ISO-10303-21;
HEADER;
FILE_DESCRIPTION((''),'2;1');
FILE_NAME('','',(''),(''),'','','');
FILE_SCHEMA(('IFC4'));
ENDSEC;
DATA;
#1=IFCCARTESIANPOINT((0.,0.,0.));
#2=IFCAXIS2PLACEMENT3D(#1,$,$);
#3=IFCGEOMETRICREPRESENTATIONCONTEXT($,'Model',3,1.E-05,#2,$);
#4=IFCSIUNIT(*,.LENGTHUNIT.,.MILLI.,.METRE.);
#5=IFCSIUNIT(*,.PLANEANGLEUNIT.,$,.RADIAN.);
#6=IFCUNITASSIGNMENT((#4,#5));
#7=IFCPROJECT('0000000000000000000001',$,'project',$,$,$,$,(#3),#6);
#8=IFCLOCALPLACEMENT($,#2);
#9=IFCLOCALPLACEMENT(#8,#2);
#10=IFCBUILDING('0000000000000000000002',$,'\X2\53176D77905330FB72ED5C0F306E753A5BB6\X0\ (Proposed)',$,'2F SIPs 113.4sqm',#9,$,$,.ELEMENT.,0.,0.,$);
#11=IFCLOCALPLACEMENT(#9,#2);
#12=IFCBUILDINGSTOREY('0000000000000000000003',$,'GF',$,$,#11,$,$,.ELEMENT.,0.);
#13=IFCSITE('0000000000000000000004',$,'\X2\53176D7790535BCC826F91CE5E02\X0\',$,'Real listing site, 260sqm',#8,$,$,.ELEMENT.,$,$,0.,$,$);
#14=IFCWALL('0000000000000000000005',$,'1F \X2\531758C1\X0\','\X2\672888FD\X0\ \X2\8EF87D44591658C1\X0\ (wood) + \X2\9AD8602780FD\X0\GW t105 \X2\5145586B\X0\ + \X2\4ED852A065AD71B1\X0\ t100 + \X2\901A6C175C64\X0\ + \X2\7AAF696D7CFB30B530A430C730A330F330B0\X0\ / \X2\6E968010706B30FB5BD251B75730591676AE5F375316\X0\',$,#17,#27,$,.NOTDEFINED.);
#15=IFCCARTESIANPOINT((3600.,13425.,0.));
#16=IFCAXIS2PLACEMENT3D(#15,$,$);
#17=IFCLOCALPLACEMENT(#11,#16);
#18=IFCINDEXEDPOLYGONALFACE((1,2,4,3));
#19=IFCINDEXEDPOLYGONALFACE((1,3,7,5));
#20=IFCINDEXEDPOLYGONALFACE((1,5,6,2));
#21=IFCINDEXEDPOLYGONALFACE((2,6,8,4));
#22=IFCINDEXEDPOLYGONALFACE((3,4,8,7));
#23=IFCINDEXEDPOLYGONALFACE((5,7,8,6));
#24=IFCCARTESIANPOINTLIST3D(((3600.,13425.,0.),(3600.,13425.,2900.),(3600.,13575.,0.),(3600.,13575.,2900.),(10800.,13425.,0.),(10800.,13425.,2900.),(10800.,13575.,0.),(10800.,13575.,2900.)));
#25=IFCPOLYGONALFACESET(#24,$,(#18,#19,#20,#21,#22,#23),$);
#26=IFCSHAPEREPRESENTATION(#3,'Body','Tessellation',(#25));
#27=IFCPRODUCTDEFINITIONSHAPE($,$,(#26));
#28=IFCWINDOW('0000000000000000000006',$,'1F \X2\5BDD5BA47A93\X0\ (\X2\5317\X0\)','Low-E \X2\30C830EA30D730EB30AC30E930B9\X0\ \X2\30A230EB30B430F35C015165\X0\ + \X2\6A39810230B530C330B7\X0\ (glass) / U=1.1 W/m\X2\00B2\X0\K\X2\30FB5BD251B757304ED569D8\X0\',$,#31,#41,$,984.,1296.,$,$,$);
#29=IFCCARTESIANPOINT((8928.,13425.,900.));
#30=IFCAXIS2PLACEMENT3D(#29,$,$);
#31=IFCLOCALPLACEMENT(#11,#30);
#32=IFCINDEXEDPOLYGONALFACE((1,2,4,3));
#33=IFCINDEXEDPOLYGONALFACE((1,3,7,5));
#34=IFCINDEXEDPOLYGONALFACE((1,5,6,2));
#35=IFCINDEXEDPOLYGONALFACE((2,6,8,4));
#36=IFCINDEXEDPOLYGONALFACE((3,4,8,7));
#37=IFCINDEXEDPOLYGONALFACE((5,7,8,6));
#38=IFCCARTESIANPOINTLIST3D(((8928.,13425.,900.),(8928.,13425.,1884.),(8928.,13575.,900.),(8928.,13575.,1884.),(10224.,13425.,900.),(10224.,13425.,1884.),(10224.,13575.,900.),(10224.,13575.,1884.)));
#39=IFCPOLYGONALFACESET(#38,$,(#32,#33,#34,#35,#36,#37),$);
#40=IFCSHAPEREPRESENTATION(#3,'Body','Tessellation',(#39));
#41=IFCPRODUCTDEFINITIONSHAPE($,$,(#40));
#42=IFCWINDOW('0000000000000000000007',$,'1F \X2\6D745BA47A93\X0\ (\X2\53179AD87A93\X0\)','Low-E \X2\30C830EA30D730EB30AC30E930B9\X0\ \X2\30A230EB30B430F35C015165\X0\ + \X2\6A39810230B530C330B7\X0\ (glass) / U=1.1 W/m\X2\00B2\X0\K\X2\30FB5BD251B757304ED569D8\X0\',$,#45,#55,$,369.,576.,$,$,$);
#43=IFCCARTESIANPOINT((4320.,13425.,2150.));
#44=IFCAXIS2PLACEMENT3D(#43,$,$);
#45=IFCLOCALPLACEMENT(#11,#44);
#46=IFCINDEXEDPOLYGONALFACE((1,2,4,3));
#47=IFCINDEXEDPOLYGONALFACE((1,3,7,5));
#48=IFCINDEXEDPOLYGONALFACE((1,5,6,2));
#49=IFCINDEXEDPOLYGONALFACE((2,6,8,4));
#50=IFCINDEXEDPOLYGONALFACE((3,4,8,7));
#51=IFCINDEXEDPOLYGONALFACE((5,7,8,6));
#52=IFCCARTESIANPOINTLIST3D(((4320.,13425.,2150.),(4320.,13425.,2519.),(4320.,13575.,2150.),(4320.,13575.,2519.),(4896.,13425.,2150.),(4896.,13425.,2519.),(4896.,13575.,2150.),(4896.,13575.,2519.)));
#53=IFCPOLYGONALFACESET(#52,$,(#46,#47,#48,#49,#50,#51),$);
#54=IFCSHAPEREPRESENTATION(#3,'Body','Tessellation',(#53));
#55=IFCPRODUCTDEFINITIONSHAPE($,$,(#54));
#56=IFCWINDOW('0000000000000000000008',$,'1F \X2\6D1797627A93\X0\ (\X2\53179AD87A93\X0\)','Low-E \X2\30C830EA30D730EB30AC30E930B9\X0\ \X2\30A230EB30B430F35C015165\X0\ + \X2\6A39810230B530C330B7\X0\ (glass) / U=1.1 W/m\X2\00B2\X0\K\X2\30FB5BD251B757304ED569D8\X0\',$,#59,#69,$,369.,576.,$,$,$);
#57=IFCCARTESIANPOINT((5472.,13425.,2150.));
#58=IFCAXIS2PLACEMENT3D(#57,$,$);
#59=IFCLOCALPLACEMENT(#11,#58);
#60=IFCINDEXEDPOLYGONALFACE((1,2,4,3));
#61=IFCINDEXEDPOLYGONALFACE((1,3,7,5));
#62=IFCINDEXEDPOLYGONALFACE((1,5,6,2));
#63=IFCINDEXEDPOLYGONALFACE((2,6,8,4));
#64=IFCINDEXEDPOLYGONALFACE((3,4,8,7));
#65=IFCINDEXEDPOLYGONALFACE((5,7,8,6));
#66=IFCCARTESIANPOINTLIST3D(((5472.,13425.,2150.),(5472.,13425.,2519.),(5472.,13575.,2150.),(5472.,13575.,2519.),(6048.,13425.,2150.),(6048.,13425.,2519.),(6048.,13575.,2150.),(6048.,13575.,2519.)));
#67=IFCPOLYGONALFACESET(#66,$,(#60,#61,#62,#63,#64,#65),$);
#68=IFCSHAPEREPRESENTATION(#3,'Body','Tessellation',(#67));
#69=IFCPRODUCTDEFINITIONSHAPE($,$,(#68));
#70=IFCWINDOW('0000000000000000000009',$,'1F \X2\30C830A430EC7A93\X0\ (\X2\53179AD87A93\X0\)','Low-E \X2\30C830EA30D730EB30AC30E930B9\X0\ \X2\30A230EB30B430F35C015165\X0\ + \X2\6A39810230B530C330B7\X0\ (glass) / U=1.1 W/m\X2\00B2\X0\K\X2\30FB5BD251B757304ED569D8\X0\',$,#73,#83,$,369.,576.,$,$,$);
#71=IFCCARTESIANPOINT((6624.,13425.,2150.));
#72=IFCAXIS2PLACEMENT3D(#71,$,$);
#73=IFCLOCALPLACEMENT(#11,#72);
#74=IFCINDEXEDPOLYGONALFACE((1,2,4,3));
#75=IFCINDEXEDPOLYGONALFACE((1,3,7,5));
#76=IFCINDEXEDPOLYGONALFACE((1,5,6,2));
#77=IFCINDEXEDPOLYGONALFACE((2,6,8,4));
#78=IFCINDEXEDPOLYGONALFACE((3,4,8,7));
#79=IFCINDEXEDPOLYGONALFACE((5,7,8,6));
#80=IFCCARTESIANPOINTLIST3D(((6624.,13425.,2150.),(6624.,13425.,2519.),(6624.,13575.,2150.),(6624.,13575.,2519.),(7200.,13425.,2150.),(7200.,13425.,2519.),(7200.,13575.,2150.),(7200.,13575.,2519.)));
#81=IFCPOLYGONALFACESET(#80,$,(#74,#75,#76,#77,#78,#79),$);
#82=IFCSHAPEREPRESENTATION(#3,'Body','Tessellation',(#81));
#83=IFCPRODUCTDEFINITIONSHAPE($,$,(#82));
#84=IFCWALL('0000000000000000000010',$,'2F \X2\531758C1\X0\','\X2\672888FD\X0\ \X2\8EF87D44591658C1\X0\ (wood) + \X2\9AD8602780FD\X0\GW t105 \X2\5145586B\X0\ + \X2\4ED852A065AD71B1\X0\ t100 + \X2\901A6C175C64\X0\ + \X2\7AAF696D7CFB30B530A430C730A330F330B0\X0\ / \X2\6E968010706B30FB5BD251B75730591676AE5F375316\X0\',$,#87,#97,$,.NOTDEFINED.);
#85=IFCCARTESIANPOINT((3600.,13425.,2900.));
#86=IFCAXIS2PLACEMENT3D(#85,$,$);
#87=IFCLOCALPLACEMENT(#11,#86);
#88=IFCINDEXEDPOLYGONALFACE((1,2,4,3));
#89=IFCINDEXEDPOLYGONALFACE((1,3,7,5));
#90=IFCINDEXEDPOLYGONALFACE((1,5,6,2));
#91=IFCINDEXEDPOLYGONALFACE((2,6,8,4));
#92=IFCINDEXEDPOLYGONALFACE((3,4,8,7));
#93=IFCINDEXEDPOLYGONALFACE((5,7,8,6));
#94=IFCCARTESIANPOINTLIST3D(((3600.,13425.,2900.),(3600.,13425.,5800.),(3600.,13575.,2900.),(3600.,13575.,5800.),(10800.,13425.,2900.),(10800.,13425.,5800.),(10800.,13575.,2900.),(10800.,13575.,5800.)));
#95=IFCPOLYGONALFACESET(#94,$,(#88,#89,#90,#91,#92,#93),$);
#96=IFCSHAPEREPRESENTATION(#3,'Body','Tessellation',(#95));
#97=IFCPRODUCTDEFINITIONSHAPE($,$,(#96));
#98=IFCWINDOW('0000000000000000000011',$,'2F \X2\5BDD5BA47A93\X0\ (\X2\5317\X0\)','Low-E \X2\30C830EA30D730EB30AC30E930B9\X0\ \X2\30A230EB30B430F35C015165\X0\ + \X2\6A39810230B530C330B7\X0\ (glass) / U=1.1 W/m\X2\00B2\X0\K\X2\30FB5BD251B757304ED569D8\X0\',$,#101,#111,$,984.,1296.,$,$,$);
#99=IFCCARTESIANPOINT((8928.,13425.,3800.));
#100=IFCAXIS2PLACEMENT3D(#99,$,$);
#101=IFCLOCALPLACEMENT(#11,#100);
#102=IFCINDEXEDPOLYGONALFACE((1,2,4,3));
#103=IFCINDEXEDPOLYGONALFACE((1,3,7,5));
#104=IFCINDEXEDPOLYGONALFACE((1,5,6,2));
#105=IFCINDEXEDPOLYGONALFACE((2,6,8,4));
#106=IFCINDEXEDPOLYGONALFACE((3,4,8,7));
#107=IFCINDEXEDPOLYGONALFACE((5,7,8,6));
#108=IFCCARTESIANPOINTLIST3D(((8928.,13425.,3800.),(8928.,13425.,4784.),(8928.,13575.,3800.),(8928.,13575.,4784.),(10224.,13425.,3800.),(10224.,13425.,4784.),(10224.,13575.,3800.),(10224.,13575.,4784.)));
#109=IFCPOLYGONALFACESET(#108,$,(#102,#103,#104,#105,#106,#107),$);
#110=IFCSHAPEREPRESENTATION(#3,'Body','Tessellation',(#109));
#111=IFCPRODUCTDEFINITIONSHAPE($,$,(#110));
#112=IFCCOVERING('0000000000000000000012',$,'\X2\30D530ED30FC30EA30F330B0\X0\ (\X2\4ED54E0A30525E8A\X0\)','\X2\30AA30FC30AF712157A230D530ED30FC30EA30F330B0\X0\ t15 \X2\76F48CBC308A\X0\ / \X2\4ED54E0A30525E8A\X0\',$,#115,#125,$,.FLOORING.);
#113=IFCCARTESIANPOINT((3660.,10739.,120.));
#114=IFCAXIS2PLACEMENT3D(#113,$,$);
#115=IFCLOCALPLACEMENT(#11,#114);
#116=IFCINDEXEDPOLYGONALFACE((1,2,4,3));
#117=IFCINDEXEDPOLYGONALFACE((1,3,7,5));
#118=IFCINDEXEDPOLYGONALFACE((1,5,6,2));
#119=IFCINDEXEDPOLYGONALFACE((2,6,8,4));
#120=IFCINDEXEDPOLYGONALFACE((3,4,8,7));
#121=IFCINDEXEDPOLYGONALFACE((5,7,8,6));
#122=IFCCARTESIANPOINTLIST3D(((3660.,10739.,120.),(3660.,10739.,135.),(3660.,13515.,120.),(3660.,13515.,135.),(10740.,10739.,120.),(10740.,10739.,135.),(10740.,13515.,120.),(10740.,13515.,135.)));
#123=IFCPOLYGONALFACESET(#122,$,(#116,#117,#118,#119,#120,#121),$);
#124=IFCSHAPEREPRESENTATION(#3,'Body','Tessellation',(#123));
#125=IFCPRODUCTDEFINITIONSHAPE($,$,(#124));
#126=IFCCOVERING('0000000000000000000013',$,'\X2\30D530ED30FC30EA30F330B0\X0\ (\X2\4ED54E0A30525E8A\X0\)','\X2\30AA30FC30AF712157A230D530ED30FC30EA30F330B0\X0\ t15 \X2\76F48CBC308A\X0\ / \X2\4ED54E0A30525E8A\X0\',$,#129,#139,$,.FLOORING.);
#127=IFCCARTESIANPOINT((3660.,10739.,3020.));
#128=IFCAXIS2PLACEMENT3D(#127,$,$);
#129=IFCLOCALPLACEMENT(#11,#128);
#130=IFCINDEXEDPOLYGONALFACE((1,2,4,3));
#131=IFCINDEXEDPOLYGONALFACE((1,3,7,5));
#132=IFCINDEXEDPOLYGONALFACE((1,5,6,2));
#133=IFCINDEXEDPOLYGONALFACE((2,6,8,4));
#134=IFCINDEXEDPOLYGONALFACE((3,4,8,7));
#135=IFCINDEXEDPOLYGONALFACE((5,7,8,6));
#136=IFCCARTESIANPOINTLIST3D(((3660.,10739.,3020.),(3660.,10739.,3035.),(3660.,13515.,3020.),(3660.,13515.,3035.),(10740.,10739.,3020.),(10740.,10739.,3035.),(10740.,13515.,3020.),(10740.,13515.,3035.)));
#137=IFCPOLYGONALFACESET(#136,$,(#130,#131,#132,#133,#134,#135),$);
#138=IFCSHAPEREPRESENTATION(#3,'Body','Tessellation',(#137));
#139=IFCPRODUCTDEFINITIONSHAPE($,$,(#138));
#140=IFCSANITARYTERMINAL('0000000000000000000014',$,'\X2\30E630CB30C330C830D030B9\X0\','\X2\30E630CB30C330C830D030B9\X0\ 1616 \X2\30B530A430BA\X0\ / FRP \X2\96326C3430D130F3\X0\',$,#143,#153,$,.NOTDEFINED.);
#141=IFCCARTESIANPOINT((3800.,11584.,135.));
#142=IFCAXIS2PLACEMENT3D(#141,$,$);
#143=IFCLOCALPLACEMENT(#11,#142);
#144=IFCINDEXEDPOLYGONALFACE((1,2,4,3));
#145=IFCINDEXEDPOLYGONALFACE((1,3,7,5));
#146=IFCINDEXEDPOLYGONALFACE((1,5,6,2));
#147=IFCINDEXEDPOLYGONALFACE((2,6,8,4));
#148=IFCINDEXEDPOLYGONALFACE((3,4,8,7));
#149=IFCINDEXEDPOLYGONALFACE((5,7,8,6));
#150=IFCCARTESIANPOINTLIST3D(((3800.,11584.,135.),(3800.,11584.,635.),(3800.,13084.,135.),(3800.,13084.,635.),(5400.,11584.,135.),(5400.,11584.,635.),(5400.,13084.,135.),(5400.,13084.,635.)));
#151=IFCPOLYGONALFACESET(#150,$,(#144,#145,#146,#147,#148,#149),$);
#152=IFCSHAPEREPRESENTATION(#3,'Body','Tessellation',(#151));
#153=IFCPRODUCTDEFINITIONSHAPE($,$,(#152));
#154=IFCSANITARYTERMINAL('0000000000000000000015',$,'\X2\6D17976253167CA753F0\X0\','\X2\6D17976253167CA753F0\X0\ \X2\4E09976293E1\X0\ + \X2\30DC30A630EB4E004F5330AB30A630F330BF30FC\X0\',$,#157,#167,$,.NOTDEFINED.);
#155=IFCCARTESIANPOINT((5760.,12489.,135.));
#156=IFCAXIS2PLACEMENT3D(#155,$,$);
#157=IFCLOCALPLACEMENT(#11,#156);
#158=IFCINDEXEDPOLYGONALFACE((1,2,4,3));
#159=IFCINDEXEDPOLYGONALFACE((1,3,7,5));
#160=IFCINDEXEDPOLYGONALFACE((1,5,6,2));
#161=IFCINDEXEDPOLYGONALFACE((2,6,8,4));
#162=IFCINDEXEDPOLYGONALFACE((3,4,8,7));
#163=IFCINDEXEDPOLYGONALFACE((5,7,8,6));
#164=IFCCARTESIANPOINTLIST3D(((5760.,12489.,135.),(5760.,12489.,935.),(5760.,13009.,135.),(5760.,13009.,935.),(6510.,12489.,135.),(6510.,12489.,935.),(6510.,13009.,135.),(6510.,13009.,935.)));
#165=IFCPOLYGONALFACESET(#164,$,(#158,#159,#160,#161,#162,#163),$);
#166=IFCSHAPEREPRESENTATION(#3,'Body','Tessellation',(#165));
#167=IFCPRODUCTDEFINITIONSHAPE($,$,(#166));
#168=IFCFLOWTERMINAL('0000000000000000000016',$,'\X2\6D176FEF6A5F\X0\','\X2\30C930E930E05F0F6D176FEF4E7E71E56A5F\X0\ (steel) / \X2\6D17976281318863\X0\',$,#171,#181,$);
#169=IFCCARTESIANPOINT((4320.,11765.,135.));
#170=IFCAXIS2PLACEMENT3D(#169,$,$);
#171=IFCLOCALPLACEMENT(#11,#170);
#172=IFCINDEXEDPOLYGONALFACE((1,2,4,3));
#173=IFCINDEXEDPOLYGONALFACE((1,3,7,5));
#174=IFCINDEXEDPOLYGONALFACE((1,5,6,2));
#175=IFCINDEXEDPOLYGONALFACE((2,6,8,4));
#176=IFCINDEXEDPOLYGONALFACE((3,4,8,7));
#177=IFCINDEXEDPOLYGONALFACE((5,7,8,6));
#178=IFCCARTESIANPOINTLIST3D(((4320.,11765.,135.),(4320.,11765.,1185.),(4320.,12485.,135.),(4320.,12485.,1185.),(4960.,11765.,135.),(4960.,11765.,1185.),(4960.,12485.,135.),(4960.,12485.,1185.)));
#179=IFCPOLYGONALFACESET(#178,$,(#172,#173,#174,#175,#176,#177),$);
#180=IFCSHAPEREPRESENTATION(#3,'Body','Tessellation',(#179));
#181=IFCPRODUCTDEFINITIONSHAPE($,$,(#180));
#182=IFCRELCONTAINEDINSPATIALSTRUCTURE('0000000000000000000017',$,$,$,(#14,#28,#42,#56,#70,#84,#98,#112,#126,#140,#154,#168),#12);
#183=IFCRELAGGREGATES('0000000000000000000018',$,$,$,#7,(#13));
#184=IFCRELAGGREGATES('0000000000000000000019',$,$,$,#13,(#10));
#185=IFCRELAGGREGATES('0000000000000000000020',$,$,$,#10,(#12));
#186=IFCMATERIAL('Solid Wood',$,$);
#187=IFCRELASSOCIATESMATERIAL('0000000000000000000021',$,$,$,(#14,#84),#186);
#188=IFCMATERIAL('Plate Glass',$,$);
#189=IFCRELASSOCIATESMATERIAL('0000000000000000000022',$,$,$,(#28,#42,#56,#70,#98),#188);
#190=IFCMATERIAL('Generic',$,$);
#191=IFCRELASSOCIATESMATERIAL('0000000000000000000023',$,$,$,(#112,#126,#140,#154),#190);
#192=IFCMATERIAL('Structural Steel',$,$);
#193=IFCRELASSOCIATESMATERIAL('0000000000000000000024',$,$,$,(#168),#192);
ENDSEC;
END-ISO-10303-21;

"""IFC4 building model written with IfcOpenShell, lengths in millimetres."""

from ifc_helpers import new_model, si_unit, frame, frame_2d, origin, place, context, project, spatial, rectangle, extrude, material, element, fill, save


model = new_model("IFC4")

# Units and contexts
model_context = context("Model", 3, precision=1e-05, world=origin())
ifc_project = project(units=[si_unit("LENGTHUNIT", "METRE", prefix="MILLI"), si_unit("PLANEANGLEUNIT", "RADIAN")], contexts=[model_context])

# Site, building, storey
site_placement = place(None, origin())
site = spatial("IfcSite", under=ifc_project, at=site_placement, Name="北海道富良野市", ObjectType="Real listing site, 260sqm", CompositionType="ELEMENT", RefElevation=0.0)
building_placement = place(site_placement, origin())
building = spatial("IfcBuilding", under=site, at=building_placement, Name="北海道・狭小の町家 (Proposed)", ObjectType="2F SIPs 113.4sqm", CompositionType="ELEMENT", ElevationOfRefHeight=0.0, ElevationOfTerrain=0.0)
storey_placement = place(building_placement, origin())
storey = spatial("IfcBuildingStorey", under=building, at=storey_placement, Name="GF", CompositionType="ELEMENT", Elevation=0.0)

# Shared definitions
ifc_material_1 = material(Name="Solid Wood")

# Wall, openings, windows
wall_1_placement = place(storey_placement, frame((3600.0, 13425.0, 0.0)))
wall_1 = element("IfcWall", 1, at=wall_1_placement, inside=storey, material=ifc_material_1, Name="1F 北壁", Description="木製 軸組外壁 (wood) + 高性能GW t105 充填 + 付加断熱 t100 + 通気層 + 窯業系サイディング / 準耐火・寒冷地外皮強化", PredefinedType="NOTDEFINED", context=model_context, shape_type="SweptSolid", body=[
    extrude(rectangle(XDim=7200.0, YDim=150.0, at=frame_2d((3600.0, 75.0))), frame((3600.0, 13425.0, 0.0)), (0.0, 0.0, 1.0), 2900.0),
])
opening_1_placement = place(storey_placement, frame((8928.0, 13425.0, 900.0)))
opening_1 = element("IfcOpeningElement", 2, at=opening_1_placement, cuts=wall_1, PredefinedType="NOTDEFINED", context=model_context, shape_type="SweptSolid", body=[
    extrude(rectangle(XDim=1296.0, YDim=150.0, at=frame_2d((648.0, 75.0))), frame((8928.0, 13425.0, 900.0)), (0.0, 0.0, 1.0), 984.0),
])
opening_2_placement = place(storey_placement, frame((4320.0, 13425.0, 2150.0)))
opening_2 = element("IfcOpeningElement", 3, at=opening_2_placement, cuts=wall_1, PredefinedType="NOTDEFINED", context=model_context, shape_type="SweptSolid", body=[
    extrude(rectangle(XDim=576.0, YDim=150.0, at=frame_2d((288.0, 75.0))), frame((4320.0, 13425.0, 2150.0)), (0.0, 0.0, 1.0), 369.0),
])
opening_3_placement = place(storey_placement, frame((5472.0, 13425.0, 2150.0)))
opening_3 = element("IfcOpeningElement", 4, at=opening_3_placement, cuts=wall_1, PredefinedType="NOTDEFINED", context=model_context, shape_type="SweptSolid", body=[
    extrude(rectangle(XDim=576.0, YDim=150.0, at=frame_2d((288.0, 75.0))), frame((5472.0, 13425.0, 2150.0)), (0.0, 0.0, 1.0), 369.0),
])
opening_4_placement = place(storey_placement, frame((6624.0, 13425.0, 2150.0)))
opening_4 = element("IfcOpeningElement", 5, at=opening_4_placement, cuts=wall_1, PredefinedType="NOTDEFINED", context=model_context, shape_type="SweptSolid", body=[
    extrude(rectangle(XDim=576.0, YDim=150.0, at=frame_2d((288.0, 75.0))), frame((6624.0, 13425.0, 2150.0)), (0.0, 0.0, 1.0), 369.0),
])
ifc_material_2 = material(Name="Plate Glass")
window_1_placement = place(storey_placement, frame((8928.0, 13425.0, 900.0)))
window_1 = element("IfcWindow", 6, at=window_1_placement, inside=storey, material=ifc_material_2, Name="1F 寝室窓 (北)", Description="Low-E トリプルガラス アルゴン封入 + 樹脂サッシ (glass) / U=1.1 W/m²K・寒冷地仕様", OverallHeight=984.0, OverallWidth=1296.0, context=model_context, shape_type="SweptSolid", body=[
    extrude(rectangle(XDim=1296.0, YDim=150.0, at=frame_2d((648.0, 75.0))), frame((8928.0, 13425.0, 900.0)), (0.0, 0.0, 1.0), 984.0),
])
fill(opening_1, window_1)
window_2_placement = place(storey_placement, frame((4320.0, 13425.0, 2150.0)))
window_2 = element("IfcWindow", 7, at=window_2_placement, inside=storey, material=ifc_material_2, Name="1F 浴室窓 (北高窓)", Description="Low-E トリプルガラス アルゴン封入 + 樹脂サッシ (glass) / U=1.1 W/m²K・寒冷地仕様", OverallHeight=369.0, OverallWidth=576.0, context=model_context, shape_type="SweptSolid", body=[
    extrude(rectangle(XDim=576.0, YDim=150.0, at=frame_2d((288.0, 75.0))), frame((4320.0, 13425.0, 2150.0)), (0.0, 0.0, 1.0), 369.0),
])
fill(opening_2, window_2)
window_3_placement = place(storey_placement, frame((5472.0, 13425.0, 2150.0)))
window_3 = element("IfcWindow", 8, at=window_3_placement, inside=storey, material=ifc_material_2, Name="1F 洗面窓 (北高窓)", Description="Low-E トリプルガラス アルゴン封入 + 樹脂サッシ (glass) / U=1.1 W/m²K・寒冷地仕様", OverallHeight=369.0, OverallWidth=576.0, context=model_context, shape_type="SweptSolid", body=[
    extrude(rectangle(XDim=576.0, YDim=150.0, at=frame_2d((288.0, 75.0))), frame((5472.0, 13425.0, 2150.0)), (0.0, 0.0, 1.0), 369.0),
])
fill(opening_3, window_3)
window_4_placement = place(storey_placement, frame((6624.0, 13425.0, 2150.0)))
window_4 = element("IfcWindow", 9, at=window_4_placement, inside=storey, material=ifc_material_2, Name="1F トイレ窓 (北高窓)", Description="Low-E トリプルガラス アルゴン封入 + 樹脂サッシ (glass) / U=1.1 W/m²K・寒冷地仕様", OverallHeight=369.0, OverallWidth=576.0, context=model_context, shape_type="SweptSolid", body=[
    extrude(rectangle(XDim=576.0, YDim=150.0, at=frame_2d((288.0, 75.0))), frame((6624.0, 13425.0, 2150.0)), (0.0, 0.0, 1.0), 369.0),
])
fill(opening_4, window_4)

# Wall, opening, window
wall_2_placement = place(storey_placement, frame((3600.0, 13425.0, 2900.0)))
wall_2 = element("IfcWall", 10, at=wall_2_placement, inside=storey, material=ifc_material_1, Name="2F 北壁", Description="木製 軸組外壁 (wood) + 高性能GW t105 充填 + 付加断熱 t100 + 通気層 + 窯業系サイディング / 準耐火・寒冷地外皮強化", PredefinedType="NOTDEFINED", context=model_context, shape_type="SweptSolid", body=[
    extrude(rectangle(XDim=7200.0, YDim=150.0, at=frame_2d((3600.0, 75.0))), frame((3600.0, 13425.0, 2900.0)), (0.0, 0.0, 1.0), 2900.0),
])
opening_5_placement = place(storey_placement, frame((8928.0, 13425.0, 3800.0)))
opening_5 = element("IfcOpeningElement", 11, at=opening_5_placement, cuts=wall_2, PredefinedType="NOTDEFINED", context=model_context, shape_type="SweptSolid", body=[
    extrude(rectangle(XDim=1296.0, YDim=150.0, at=frame_2d((648.0, 75.0))), frame((8928.0, 13425.0, 3800.0)), (0.0, 0.0, 1.0), 984.0),
])
window_5_placement = place(storey_placement, frame((8928.0, 13425.0, 3800.0)))
window_5 = element("IfcWindow", 12, at=window_5_placement, inside=storey, material=ifc_material_2, Name="2F 寝室窓 (北)", Description="Low-E トリプルガラス アルゴン封入 + 樹脂サッシ (glass) / U=1.1 W/m²K・寒冷地仕様", OverallHeight=984.0, OverallWidth=1296.0, context=model_context, shape_type="SweptSolid", body=[
    extrude(rectangle(XDim=1296.0, YDim=150.0, at=frame_2d((648.0, 75.0))), frame((8928.0, 13425.0, 3800.0)), (0.0, 0.0, 1.0), 984.0),
])
fill(opening_5, window_5)

# Coverings
ifc_material_3 = material(Name="Generic")
covering_1_placement = place(storey_placement, frame((3660.0, 10739.0, 120.0)))
element("IfcCovering", 13, at=covering_1_placement, inside=storey, material=ifc_material_3, Name="フローリング (仕上げ床)", Description="オーク無垢フローリング t15 直貼り / 仕上げ床", PredefinedType="FLOORING", context=model_context, shape_type="SweptSolid", body=[
    extrude(rectangle(XDim=7080.0, YDim=2776.0, at=frame_2d((3540.0, 1388.0))), frame((3660.0, 10739.0, 120.0)), (0.0, 0.0, 1.0), 15.0),
])
covering_2_placement = place(storey_placement, frame((3660.0, 10739.0, 3020.0)))
element("IfcCovering", 14, at=covering_2_placement, inside=storey, material=ifc_material_3, Name="フローリング (仕上げ床)", Description="オーク無垢フローリング t15 直貼り / 仕上げ床", PredefinedType="FLOORING", context=model_context, shape_type="SweptSolid", body=[
    extrude(rectangle(XDim=7080.0, YDim=2776.0, at=frame_2d((3540.0, 1388.0))), frame((3660.0, 10739.0, 3020.0)), (0.0, 0.0, 1.0), 15.0),
])

# Sanitary terminals
sanitary_terminal_1_placement = place(storey_placement, frame((3800.0, 11584.0, 135.0)))
element("IfcSanitaryTerminal", 15, at=sanitary_terminal_1_placement, inside=storey, material=ifc_material_3, Name="ユニットバス", Description="ユニットバス 1616 サイズ / FRP 防水パン", PredefinedType="NOTDEFINED", context=model_context, shape_type="SweptSolid", body=[
    extrude(rectangle(XDim=1600.0, YDim=1500.0, at=frame_2d((800.0, 750.0))), frame((3800.0, 11584.0, 135.0)), (0.0, 0.0, 1.0), 500.0),
])
sanitary_terminal_2_placement = place(storey_placement, frame((5760.0, 12489.0, 135.0)))
element("IfcSanitaryTerminal", 16, at=sanitary_terminal_2_placement, inside=storey, material=ifc_material_3, Name="洗面化粧台", Description="洗面化粧台 三面鏡 + ボウル一体カウンター", PredefinedType="NOTDEFINED", context=model_context, shape_type="SweptSolid", body=[
    extrude(rectangle(XDim=750.0, YDim=520.0, at=frame_2d((375.0, 260.0))), frame((5760.0, 12489.0, 135.0)), (0.0, 0.0, 1.0), 800.0),
])

# Flow terminal
ifc_material_4 = material(Name="Structural Steel")
flow_terminal_placement = place(storey_placement, frame((4320.0, 11765.0, 135.0)))
element("IfcFlowTerminal", 17, at=flow_terminal_placement, inside=storey, material=ifc_material_4, Name="洗濯機", Description="ドラム式洗濯乾燥機 (steel) / 洗面脱衣", context=model_context, shape_type="SweptSolid", body=[
    extrude(rectangle(XDim=640.0, YDim=720.0, at=frame_2d((320.0, 360.0))), frame((4320.0, 11765.0, 135.0)), (0.0, 0.0, 1.0), 1050.0),
])

save(model, "model.ifc")
